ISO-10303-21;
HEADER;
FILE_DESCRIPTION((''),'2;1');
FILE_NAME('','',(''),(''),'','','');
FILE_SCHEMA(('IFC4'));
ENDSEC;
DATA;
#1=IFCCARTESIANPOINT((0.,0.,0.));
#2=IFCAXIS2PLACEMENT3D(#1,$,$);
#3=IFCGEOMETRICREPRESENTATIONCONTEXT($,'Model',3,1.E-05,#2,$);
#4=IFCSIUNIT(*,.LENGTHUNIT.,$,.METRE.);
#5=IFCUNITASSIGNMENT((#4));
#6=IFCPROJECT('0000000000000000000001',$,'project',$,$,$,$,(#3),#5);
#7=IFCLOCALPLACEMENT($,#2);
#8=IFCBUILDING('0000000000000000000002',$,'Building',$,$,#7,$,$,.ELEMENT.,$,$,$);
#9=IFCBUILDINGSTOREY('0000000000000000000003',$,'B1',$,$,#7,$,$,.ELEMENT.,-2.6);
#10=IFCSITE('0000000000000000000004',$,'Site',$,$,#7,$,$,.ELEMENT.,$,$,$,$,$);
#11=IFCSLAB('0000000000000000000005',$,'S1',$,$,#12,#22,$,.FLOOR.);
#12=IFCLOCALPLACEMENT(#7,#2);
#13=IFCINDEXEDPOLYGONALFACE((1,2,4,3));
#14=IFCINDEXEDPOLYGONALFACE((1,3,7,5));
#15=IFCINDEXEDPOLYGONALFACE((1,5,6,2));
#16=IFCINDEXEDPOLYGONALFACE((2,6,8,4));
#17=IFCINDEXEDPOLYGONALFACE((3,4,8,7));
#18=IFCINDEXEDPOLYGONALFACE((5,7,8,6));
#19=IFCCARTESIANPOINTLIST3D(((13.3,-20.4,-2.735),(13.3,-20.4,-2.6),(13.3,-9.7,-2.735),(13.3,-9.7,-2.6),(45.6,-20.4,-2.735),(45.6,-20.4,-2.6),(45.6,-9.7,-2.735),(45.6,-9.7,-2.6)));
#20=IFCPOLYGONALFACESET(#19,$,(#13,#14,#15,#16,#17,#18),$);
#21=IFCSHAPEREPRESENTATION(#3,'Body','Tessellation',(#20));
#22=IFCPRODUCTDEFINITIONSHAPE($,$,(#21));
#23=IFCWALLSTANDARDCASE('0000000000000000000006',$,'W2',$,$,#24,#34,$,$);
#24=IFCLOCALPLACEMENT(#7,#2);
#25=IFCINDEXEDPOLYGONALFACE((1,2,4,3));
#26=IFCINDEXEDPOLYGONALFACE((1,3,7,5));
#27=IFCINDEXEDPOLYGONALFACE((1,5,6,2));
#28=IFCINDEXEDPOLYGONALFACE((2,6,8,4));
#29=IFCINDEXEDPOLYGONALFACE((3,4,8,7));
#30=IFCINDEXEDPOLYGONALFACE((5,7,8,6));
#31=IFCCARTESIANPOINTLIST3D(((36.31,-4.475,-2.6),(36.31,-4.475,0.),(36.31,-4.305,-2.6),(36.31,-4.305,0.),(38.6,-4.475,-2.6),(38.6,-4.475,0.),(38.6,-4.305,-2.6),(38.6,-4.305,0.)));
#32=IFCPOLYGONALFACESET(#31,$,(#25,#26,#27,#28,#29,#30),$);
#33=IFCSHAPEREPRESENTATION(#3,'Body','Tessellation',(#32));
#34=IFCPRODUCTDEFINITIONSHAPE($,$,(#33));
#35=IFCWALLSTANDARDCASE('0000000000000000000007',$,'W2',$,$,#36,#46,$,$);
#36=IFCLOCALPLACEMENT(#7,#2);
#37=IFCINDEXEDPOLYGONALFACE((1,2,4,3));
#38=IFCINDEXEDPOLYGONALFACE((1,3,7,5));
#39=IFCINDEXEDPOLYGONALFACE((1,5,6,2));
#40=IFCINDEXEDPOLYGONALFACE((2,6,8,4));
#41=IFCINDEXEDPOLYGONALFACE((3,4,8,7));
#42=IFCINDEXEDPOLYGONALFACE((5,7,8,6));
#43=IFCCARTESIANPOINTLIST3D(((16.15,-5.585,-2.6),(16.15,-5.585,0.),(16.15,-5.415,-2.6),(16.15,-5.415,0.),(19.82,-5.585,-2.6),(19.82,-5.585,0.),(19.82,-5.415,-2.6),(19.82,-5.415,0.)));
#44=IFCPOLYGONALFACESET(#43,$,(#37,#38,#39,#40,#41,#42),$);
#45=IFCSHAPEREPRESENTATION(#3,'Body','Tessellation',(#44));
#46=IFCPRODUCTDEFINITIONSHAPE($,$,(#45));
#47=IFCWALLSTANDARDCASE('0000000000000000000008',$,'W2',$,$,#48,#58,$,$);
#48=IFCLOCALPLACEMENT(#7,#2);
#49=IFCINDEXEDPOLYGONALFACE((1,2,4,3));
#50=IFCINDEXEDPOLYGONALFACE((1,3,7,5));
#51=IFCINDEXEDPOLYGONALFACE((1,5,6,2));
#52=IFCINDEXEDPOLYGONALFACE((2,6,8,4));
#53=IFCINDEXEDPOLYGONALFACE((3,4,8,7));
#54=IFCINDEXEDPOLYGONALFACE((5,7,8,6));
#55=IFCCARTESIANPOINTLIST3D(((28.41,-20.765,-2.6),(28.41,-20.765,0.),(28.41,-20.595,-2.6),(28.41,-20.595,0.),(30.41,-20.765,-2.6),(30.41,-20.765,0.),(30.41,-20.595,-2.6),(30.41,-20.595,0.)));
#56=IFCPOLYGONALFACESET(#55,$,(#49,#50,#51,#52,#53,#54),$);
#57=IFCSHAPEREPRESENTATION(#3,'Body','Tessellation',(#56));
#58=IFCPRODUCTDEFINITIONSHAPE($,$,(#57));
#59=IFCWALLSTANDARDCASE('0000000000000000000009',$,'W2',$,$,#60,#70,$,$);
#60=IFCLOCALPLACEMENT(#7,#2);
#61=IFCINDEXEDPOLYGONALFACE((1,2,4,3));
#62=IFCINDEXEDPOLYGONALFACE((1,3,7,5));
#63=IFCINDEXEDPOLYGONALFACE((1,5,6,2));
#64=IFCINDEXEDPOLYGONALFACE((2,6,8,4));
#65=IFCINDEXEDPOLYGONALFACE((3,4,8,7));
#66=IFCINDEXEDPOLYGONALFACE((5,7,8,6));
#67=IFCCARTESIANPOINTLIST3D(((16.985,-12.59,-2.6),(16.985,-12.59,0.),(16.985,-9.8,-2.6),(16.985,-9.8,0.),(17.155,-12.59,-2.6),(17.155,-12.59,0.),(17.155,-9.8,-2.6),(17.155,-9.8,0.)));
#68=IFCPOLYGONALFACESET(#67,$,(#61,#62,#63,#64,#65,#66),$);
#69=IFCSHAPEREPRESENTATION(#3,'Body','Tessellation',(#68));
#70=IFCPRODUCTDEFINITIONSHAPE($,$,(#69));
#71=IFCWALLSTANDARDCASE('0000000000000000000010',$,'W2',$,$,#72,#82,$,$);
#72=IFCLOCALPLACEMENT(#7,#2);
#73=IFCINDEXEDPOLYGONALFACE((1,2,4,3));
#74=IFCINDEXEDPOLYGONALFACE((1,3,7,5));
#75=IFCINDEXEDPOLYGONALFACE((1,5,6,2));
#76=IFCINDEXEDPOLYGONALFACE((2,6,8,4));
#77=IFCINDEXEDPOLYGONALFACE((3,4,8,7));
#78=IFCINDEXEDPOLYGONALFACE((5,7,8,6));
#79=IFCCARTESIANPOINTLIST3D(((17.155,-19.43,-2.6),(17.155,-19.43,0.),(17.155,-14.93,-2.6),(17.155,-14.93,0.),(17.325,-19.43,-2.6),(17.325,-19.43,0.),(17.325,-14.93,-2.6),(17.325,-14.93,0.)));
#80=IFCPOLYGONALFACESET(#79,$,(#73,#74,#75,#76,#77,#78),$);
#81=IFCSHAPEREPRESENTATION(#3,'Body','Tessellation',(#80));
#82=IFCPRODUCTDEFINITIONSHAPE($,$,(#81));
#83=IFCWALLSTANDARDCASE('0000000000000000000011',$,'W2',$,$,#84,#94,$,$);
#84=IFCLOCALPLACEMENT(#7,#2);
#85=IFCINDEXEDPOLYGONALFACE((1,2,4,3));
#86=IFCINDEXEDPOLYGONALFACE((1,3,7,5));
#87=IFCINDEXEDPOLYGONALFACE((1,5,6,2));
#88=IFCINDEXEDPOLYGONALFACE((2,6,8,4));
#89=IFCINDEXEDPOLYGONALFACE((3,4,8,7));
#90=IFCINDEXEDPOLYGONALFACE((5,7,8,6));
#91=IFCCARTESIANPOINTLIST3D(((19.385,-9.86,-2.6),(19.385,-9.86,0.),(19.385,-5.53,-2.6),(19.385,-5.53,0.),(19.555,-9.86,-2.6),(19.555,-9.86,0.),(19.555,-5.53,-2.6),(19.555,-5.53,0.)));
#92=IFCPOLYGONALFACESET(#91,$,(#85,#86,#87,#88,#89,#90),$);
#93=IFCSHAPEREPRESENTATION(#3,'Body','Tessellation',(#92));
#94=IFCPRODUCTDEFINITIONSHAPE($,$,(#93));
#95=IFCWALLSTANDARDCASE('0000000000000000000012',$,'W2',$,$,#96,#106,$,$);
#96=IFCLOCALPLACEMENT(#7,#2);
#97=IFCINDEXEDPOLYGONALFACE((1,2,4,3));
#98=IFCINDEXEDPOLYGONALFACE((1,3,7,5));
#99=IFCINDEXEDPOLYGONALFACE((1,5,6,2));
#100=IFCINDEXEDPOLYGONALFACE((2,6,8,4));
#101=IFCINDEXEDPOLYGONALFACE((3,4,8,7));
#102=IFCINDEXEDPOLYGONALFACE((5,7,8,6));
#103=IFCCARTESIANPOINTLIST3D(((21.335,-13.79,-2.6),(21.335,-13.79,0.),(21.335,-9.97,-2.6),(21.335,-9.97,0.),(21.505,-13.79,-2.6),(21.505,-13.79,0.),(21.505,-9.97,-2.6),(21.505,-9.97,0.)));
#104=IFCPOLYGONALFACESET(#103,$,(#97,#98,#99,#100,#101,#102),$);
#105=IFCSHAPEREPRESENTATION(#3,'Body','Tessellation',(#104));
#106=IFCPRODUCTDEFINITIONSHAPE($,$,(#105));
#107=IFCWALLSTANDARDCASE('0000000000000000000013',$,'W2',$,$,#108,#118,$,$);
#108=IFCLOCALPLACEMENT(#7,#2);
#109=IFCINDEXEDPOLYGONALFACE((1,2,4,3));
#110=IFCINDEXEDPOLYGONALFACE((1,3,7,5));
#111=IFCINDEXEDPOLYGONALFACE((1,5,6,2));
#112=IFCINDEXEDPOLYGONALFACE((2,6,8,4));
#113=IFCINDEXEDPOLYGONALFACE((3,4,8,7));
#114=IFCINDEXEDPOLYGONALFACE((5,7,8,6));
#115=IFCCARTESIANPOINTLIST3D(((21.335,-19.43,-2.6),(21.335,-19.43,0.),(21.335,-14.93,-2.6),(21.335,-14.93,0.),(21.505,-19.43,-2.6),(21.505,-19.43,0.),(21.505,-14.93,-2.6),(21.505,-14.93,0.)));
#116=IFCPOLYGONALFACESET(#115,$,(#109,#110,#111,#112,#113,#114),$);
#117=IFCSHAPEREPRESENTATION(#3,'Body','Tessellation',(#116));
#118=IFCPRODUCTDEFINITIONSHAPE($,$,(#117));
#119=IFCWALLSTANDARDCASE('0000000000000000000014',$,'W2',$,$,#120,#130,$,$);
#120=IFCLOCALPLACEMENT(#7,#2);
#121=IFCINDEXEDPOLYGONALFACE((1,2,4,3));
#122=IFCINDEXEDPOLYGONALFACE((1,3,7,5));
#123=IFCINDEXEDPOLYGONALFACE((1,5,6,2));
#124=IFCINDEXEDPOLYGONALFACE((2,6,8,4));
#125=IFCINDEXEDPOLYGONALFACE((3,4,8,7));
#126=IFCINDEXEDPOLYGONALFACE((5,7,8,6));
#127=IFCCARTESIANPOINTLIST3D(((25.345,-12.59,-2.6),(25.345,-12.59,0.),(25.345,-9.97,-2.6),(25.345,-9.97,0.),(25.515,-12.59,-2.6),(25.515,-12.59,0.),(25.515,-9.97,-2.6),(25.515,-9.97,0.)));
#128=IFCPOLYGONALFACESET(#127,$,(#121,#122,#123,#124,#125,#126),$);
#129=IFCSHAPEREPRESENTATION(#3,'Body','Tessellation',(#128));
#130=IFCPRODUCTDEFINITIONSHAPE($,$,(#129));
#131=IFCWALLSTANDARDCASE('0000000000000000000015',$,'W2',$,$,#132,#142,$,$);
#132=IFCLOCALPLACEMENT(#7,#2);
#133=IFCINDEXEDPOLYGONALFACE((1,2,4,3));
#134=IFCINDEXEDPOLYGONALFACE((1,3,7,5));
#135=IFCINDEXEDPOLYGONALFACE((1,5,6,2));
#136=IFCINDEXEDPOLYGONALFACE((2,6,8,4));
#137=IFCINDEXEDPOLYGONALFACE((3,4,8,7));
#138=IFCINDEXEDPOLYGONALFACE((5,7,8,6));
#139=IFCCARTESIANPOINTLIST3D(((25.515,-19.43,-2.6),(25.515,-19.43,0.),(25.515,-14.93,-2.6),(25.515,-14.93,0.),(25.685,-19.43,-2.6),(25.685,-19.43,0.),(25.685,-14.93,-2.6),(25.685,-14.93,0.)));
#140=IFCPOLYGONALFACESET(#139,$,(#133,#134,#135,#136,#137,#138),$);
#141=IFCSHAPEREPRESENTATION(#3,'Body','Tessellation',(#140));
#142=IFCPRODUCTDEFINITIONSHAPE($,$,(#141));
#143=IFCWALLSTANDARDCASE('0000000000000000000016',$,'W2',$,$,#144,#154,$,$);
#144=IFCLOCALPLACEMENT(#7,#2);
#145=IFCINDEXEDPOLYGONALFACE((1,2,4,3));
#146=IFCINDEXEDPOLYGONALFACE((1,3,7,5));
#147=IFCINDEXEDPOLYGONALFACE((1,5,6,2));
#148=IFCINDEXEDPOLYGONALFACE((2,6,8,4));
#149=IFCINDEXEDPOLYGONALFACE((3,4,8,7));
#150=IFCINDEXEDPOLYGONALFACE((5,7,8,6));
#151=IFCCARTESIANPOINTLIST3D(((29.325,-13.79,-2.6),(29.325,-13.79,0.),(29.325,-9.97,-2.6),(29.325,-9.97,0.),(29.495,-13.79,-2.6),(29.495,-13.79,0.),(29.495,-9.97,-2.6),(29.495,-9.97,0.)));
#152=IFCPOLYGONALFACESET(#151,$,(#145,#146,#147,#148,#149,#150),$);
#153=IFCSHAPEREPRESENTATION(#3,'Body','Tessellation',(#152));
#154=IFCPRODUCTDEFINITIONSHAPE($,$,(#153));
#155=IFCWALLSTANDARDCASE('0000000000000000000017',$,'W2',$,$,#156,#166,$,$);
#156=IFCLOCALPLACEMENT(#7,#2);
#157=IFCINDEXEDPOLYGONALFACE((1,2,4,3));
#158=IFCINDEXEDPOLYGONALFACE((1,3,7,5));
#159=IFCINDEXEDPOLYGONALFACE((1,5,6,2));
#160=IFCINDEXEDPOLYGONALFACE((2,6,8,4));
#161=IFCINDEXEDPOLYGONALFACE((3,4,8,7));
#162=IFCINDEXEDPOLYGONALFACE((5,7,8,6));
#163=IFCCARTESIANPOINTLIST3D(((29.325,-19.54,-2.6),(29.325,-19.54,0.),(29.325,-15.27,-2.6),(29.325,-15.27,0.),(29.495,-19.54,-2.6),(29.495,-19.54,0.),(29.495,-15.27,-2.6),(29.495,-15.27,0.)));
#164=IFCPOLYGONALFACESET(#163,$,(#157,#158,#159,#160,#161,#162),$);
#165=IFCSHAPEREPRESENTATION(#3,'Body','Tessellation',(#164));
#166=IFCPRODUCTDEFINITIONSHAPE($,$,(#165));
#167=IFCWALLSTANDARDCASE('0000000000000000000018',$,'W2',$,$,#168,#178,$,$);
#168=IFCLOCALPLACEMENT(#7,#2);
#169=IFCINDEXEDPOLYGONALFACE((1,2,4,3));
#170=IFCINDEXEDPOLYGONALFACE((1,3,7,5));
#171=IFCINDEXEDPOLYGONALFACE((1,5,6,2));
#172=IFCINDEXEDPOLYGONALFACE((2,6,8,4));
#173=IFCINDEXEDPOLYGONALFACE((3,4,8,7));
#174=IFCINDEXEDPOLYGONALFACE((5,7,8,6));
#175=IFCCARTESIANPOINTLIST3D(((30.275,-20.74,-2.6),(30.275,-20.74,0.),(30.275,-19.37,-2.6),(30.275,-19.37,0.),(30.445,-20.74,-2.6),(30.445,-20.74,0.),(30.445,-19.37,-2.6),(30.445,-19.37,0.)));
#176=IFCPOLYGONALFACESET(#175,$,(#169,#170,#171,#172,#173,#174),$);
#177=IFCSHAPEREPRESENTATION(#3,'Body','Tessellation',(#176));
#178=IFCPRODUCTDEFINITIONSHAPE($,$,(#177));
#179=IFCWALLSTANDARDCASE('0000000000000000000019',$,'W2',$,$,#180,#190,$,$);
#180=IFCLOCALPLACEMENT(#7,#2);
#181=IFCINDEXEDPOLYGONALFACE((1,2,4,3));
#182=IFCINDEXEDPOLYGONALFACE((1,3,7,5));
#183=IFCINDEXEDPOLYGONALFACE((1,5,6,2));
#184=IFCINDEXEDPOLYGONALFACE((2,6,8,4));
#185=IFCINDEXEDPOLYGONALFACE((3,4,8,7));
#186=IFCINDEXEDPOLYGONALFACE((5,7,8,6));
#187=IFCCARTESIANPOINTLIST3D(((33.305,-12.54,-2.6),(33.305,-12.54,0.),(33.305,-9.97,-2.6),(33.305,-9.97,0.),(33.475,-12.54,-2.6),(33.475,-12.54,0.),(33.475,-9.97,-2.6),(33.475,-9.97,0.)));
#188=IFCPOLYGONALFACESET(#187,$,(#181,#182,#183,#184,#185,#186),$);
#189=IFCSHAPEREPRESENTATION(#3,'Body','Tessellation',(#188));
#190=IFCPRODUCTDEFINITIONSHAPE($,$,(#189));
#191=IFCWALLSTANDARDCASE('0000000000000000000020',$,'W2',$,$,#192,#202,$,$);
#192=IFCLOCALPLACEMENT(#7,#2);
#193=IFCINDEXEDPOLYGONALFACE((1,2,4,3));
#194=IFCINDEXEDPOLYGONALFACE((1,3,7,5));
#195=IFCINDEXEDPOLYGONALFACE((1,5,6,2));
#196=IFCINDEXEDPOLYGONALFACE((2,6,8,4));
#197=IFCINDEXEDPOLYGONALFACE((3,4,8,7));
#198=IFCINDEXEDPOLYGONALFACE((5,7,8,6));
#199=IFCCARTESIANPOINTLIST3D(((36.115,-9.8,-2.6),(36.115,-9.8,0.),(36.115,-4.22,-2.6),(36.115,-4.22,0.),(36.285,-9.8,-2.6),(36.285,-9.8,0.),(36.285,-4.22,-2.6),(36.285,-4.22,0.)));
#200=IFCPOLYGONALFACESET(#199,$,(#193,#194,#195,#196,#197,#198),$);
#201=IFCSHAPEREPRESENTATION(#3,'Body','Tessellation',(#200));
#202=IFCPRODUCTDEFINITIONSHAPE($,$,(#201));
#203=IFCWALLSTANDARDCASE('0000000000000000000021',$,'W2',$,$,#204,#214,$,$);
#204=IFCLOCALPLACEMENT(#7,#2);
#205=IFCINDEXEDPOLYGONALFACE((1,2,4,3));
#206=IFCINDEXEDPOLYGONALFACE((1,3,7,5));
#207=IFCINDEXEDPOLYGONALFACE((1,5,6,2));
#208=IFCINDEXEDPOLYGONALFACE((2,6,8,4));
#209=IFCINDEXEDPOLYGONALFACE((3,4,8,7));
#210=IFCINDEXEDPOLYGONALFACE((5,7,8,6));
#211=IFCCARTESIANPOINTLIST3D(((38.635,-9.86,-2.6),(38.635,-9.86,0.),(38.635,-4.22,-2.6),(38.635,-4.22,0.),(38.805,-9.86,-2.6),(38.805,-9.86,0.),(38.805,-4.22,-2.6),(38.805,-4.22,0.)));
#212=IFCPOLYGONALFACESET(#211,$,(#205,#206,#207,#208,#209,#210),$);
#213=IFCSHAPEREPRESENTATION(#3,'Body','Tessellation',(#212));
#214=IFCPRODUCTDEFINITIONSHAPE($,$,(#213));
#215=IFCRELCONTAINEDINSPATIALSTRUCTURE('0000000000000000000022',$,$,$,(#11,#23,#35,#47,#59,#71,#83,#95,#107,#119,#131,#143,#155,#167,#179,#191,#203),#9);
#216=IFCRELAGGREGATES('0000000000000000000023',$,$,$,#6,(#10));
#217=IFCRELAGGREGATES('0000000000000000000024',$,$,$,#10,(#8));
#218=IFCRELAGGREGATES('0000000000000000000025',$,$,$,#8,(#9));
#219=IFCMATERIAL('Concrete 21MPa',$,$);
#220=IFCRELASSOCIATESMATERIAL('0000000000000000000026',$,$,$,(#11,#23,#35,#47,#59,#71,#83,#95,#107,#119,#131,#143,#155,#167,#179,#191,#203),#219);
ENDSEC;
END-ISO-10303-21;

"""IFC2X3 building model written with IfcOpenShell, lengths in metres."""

from ifc_helpers import new_model, si_unit, frame, origin, origin_2d, place, context, project, spatial, rectangle, extrude, material, element, save


model = new_model("IFC2X3")

# Units and contexts
model_context = context("Model", 3, precision=1e-05, world=origin())
ifc_project = project(units=[si_unit("LENGTHUNIT", "METRE")], contexts=[model_context])

# Site, building, storey
placement = place(None, origin())
site = spatial("IfcSite", under=ifc_project, at=placement, Name="Site", CompositionType="ELEMENT")
building = spatial("IfcBuilding", under=site, at=placement, Name="Building", CompositionType="ELEMENT")
storey = spatial("IfcBuildingStorey", under=building, at=placement, Name="B1", CompositionType="ELEMENT", Elevation=-2.6)

# Slab
ifc_material_1 = material(Name="Concrete 21MPa")
slab_placement = place(None, frame((29.45, -15.05, -2.735)))
element("IfcSlab", 1, at=slab_placement, inside=storey, material=ifc_material_1, Name="S1", PredefinedType="FLOOR", context=model_context, shape_type="SweptSolid", body=[
    extrude(rectangle(XDim=32.3, YDim=10.7, at=origin_2d()), origin(), (0.0, 0.0, 1.0), 0.135),
])

# Walls
wall_1_placement = place(None, frame((37.455, -4.39, -2.6)))
element("IfcWallStandardCase", 2, at=wall_1_placement, inside=storey, material=ifc_material_1, Name="W2", context=model_context, shape_type="SweptSolid", body=[
    extrude(rectangle(XDim=2.29, YDim=0.17, at=origin_2d()), origin(), (0.0, 0.0, 1.0), 2.6),
])
wall_2_placement = place(None, frame((17.985, -5.5, -2.6)))
element("IfcWallStandardCase", 3, at=wall_2_placement, inside=storey, material=ifc_material_1, Name="W2", context=model_context, shape_type="SweptSolid", body=[
    extrude(rectangle(XDim=3.67, YDim=0.17, at=origin_2d()), origin(), (0.0, 0.0, 1.0), 2.6),
])
wall_3_placement = place(None, frame((29.41, -20.68, -2.6)))
element("IfcWallStandardCase", 4, at=wall_3_placement, inside=storey, material=ifc_material_1, Name="W2", context=model_context, shape_type="SweptSolid", body=[
    extrude(rectangle(XDim=2.0, YDim=0.17, at=origin_2d()), origin(), (0.0, 0.0, 1.0), 2.6),
])
wall_4_placement = place(None, frame((17.07, -11.195, -2.6)))
element("IfcWallStandardCase", 5, at=wall_4_placement, inside=storey, material=ifc_material_1, Name="W2", context=model_context, shape_type="SweptSolid", body=[
    extrude(rectangle(XDim=0.17, YDim=2.79, at=origin_2d()), origin(), (0.0, 0.0, 1.0), 2.6),
])
wall_5_placement = place(None, frame((17.24, -17.18, -2.6)))
element("IfcWallStandardCase", 6, at=wall_5_placement, inside=storey, material=ifc_material_1, Name="W2", context=model_context, shape_type="SweptSolid", body=[
    extrude(rectangle(XDim=0.17, YDim=4.5, at=origin_2d()), origin(), (0.0, 0.0, 1.0), 2.6),
])
wall_6_placement = place(None, frame((19.47, -7.695, -2.6)))
element("IfcWallStandardCase", 7, at=wall_6_placement, inside=storey, material=ifc_material_1, Name="W2", context=model_context, shape_type="SweptSolid", body=[
    extrude(rectangle(XDim=0.17, YDim=4.33, at=origin_2d()), origin(), (0.0, 0.0, 1.0), 2.6),
])
wall_7_placement = place(None, frame((21.42, -11.88, -2.6)))
element("IfcWallStandardCase", 8, at=wall_7_placement, inside=storey, material=ifc_material_1, Name="W2", context=model_context, shape_type="SweptSolid", body=[
    extrude(rectangle(XDim=0.17, YDim=3.82, at=origin_2d()), origin(), (0.0, 0.0, 1.0), 2.6),
])
wall_8_placement = place(None, frame((21.42, -17.18, -2.6)))
element("IfcWallStandardCase", 9, at=wall_8_placement, inside=storey, material=ifc_material_1, Name="W2", context=model_context, shape_type="SweptSolid", body=[
    extrude(rectangle(XDim=0.17, YDim=4.5, at=origin_2d()), origin(), (0.0, 0.0, 1.0), 2.6),
])
wall_9_placement = place(None, frame((25.43, -11.28, -2.6)))
element("IfcWallStandardCase", 10, at=wall_9_placement, inside=storey, material=ifc_material_1, Name="W2", context=model_context, shape_type="SweptSolid", body=[
    extrude(rectangle(XDim=0.17, YDim=2.62, at=origin_2d()), origin(), (0.0, 0.0, 1.0), 2.6),
])
wall_10_placement = place(None, frame((25.6, -17.18, -2.6)))
element("IfcWallStandardCase", 11, at=wall_10_placement, inside=storey, material=ifc_material_1, Name="W2", context=model_context, shape_type="SweptSolid", body=[
    extrude(rectangle(XDim=0.17, YDim=4.5, at=origin_2d()), origin(), (0.0, 0.0, 1.0), 2.6),
])
wall_11_placement = place(None, frame((29.41, -11.88, -2.6)))
element("IfcWallStandardCase", 12, at=wall_11_placement, inside=storey, material=ifc_material_1, Name="W2", context=model_context, shape_type="SweptSolid", body=[
    extrude(rectangle(XDim=0.17, YDim=3.82, at=origin_2d()), origin(), (0.0, 0.0, 1.0), 2.6),
])
wall_12_placement = place(None, frame((29.41, -17.405, -2.6)))
element("IfcWallStandardCase", 13, at=wall_12_placement, inside=storey, material=ifc_material_1, Name="W2", context=model_context, shape_type="SweptSolid", body=[
    extrude(rectangle(XDim=0.17, YDim=4.27, at=origin_2d()), origin(), (0.0, 0.0, 1.0), 2.6),
])
wall_13_placement = place(None, frame((30.36, -20.055, -2.6)))
element("IfcWallStandardCase", 14, at=wall_13_placement, inside=storey, material=ifc_material_1, Name="W2", context=model_context, shape_type="SweptSolid", body=[
    extrude(rectangle(XDim=0.17, YDim=1.37, at=origin_2d()), origin(), (0.0, 0.0, 1.0), 2.6),
])
wall_14_placement = place(None, frame((33.39, -11.255, -2.6)))
element("IfcWallStandardCase", 15, at=wall_14_placement, inside=storey, material=ifc_material_1, Name="W2", context=model_context, shape_type="SweptSolid", body=[
    extrude(rectangle(XDim=0.17, YDim=2.57, at=origin_2d()), origin(), (0.0, 0.0, 1.0), 2.6),
])
wall_15_placement = place(None, frame((36.2, -7.01, -2.6)))
element("IfcWallStandardCase", 16, at=wall_15_placement, inside=storey, material=ifc_material_1, Name="W2", context=model_context, shape_type="SweptSolid", body=[
    extrude(rectangle(XDim=0.17, YDim=5.58, at=origin_2d()), origin(), (0.0, 0.0, 1.0), 2.6),
])
wall_16_placement = place(None, frame((38.72, -7.04, -2.6)))
element("IfcWallStandardCase", 17, at=wall_16_placement, inside=storey, material=ifc_material_1, Name="W2", context=model_context, shape_type="SweptSolid", body=[
    extrude(rectangle(XDim=0.17, YDim=5.64, at=origin_2d()), origin(), (0.0, 0.0, 1.0), 2.6),
])

save(model, "model.ifc")
